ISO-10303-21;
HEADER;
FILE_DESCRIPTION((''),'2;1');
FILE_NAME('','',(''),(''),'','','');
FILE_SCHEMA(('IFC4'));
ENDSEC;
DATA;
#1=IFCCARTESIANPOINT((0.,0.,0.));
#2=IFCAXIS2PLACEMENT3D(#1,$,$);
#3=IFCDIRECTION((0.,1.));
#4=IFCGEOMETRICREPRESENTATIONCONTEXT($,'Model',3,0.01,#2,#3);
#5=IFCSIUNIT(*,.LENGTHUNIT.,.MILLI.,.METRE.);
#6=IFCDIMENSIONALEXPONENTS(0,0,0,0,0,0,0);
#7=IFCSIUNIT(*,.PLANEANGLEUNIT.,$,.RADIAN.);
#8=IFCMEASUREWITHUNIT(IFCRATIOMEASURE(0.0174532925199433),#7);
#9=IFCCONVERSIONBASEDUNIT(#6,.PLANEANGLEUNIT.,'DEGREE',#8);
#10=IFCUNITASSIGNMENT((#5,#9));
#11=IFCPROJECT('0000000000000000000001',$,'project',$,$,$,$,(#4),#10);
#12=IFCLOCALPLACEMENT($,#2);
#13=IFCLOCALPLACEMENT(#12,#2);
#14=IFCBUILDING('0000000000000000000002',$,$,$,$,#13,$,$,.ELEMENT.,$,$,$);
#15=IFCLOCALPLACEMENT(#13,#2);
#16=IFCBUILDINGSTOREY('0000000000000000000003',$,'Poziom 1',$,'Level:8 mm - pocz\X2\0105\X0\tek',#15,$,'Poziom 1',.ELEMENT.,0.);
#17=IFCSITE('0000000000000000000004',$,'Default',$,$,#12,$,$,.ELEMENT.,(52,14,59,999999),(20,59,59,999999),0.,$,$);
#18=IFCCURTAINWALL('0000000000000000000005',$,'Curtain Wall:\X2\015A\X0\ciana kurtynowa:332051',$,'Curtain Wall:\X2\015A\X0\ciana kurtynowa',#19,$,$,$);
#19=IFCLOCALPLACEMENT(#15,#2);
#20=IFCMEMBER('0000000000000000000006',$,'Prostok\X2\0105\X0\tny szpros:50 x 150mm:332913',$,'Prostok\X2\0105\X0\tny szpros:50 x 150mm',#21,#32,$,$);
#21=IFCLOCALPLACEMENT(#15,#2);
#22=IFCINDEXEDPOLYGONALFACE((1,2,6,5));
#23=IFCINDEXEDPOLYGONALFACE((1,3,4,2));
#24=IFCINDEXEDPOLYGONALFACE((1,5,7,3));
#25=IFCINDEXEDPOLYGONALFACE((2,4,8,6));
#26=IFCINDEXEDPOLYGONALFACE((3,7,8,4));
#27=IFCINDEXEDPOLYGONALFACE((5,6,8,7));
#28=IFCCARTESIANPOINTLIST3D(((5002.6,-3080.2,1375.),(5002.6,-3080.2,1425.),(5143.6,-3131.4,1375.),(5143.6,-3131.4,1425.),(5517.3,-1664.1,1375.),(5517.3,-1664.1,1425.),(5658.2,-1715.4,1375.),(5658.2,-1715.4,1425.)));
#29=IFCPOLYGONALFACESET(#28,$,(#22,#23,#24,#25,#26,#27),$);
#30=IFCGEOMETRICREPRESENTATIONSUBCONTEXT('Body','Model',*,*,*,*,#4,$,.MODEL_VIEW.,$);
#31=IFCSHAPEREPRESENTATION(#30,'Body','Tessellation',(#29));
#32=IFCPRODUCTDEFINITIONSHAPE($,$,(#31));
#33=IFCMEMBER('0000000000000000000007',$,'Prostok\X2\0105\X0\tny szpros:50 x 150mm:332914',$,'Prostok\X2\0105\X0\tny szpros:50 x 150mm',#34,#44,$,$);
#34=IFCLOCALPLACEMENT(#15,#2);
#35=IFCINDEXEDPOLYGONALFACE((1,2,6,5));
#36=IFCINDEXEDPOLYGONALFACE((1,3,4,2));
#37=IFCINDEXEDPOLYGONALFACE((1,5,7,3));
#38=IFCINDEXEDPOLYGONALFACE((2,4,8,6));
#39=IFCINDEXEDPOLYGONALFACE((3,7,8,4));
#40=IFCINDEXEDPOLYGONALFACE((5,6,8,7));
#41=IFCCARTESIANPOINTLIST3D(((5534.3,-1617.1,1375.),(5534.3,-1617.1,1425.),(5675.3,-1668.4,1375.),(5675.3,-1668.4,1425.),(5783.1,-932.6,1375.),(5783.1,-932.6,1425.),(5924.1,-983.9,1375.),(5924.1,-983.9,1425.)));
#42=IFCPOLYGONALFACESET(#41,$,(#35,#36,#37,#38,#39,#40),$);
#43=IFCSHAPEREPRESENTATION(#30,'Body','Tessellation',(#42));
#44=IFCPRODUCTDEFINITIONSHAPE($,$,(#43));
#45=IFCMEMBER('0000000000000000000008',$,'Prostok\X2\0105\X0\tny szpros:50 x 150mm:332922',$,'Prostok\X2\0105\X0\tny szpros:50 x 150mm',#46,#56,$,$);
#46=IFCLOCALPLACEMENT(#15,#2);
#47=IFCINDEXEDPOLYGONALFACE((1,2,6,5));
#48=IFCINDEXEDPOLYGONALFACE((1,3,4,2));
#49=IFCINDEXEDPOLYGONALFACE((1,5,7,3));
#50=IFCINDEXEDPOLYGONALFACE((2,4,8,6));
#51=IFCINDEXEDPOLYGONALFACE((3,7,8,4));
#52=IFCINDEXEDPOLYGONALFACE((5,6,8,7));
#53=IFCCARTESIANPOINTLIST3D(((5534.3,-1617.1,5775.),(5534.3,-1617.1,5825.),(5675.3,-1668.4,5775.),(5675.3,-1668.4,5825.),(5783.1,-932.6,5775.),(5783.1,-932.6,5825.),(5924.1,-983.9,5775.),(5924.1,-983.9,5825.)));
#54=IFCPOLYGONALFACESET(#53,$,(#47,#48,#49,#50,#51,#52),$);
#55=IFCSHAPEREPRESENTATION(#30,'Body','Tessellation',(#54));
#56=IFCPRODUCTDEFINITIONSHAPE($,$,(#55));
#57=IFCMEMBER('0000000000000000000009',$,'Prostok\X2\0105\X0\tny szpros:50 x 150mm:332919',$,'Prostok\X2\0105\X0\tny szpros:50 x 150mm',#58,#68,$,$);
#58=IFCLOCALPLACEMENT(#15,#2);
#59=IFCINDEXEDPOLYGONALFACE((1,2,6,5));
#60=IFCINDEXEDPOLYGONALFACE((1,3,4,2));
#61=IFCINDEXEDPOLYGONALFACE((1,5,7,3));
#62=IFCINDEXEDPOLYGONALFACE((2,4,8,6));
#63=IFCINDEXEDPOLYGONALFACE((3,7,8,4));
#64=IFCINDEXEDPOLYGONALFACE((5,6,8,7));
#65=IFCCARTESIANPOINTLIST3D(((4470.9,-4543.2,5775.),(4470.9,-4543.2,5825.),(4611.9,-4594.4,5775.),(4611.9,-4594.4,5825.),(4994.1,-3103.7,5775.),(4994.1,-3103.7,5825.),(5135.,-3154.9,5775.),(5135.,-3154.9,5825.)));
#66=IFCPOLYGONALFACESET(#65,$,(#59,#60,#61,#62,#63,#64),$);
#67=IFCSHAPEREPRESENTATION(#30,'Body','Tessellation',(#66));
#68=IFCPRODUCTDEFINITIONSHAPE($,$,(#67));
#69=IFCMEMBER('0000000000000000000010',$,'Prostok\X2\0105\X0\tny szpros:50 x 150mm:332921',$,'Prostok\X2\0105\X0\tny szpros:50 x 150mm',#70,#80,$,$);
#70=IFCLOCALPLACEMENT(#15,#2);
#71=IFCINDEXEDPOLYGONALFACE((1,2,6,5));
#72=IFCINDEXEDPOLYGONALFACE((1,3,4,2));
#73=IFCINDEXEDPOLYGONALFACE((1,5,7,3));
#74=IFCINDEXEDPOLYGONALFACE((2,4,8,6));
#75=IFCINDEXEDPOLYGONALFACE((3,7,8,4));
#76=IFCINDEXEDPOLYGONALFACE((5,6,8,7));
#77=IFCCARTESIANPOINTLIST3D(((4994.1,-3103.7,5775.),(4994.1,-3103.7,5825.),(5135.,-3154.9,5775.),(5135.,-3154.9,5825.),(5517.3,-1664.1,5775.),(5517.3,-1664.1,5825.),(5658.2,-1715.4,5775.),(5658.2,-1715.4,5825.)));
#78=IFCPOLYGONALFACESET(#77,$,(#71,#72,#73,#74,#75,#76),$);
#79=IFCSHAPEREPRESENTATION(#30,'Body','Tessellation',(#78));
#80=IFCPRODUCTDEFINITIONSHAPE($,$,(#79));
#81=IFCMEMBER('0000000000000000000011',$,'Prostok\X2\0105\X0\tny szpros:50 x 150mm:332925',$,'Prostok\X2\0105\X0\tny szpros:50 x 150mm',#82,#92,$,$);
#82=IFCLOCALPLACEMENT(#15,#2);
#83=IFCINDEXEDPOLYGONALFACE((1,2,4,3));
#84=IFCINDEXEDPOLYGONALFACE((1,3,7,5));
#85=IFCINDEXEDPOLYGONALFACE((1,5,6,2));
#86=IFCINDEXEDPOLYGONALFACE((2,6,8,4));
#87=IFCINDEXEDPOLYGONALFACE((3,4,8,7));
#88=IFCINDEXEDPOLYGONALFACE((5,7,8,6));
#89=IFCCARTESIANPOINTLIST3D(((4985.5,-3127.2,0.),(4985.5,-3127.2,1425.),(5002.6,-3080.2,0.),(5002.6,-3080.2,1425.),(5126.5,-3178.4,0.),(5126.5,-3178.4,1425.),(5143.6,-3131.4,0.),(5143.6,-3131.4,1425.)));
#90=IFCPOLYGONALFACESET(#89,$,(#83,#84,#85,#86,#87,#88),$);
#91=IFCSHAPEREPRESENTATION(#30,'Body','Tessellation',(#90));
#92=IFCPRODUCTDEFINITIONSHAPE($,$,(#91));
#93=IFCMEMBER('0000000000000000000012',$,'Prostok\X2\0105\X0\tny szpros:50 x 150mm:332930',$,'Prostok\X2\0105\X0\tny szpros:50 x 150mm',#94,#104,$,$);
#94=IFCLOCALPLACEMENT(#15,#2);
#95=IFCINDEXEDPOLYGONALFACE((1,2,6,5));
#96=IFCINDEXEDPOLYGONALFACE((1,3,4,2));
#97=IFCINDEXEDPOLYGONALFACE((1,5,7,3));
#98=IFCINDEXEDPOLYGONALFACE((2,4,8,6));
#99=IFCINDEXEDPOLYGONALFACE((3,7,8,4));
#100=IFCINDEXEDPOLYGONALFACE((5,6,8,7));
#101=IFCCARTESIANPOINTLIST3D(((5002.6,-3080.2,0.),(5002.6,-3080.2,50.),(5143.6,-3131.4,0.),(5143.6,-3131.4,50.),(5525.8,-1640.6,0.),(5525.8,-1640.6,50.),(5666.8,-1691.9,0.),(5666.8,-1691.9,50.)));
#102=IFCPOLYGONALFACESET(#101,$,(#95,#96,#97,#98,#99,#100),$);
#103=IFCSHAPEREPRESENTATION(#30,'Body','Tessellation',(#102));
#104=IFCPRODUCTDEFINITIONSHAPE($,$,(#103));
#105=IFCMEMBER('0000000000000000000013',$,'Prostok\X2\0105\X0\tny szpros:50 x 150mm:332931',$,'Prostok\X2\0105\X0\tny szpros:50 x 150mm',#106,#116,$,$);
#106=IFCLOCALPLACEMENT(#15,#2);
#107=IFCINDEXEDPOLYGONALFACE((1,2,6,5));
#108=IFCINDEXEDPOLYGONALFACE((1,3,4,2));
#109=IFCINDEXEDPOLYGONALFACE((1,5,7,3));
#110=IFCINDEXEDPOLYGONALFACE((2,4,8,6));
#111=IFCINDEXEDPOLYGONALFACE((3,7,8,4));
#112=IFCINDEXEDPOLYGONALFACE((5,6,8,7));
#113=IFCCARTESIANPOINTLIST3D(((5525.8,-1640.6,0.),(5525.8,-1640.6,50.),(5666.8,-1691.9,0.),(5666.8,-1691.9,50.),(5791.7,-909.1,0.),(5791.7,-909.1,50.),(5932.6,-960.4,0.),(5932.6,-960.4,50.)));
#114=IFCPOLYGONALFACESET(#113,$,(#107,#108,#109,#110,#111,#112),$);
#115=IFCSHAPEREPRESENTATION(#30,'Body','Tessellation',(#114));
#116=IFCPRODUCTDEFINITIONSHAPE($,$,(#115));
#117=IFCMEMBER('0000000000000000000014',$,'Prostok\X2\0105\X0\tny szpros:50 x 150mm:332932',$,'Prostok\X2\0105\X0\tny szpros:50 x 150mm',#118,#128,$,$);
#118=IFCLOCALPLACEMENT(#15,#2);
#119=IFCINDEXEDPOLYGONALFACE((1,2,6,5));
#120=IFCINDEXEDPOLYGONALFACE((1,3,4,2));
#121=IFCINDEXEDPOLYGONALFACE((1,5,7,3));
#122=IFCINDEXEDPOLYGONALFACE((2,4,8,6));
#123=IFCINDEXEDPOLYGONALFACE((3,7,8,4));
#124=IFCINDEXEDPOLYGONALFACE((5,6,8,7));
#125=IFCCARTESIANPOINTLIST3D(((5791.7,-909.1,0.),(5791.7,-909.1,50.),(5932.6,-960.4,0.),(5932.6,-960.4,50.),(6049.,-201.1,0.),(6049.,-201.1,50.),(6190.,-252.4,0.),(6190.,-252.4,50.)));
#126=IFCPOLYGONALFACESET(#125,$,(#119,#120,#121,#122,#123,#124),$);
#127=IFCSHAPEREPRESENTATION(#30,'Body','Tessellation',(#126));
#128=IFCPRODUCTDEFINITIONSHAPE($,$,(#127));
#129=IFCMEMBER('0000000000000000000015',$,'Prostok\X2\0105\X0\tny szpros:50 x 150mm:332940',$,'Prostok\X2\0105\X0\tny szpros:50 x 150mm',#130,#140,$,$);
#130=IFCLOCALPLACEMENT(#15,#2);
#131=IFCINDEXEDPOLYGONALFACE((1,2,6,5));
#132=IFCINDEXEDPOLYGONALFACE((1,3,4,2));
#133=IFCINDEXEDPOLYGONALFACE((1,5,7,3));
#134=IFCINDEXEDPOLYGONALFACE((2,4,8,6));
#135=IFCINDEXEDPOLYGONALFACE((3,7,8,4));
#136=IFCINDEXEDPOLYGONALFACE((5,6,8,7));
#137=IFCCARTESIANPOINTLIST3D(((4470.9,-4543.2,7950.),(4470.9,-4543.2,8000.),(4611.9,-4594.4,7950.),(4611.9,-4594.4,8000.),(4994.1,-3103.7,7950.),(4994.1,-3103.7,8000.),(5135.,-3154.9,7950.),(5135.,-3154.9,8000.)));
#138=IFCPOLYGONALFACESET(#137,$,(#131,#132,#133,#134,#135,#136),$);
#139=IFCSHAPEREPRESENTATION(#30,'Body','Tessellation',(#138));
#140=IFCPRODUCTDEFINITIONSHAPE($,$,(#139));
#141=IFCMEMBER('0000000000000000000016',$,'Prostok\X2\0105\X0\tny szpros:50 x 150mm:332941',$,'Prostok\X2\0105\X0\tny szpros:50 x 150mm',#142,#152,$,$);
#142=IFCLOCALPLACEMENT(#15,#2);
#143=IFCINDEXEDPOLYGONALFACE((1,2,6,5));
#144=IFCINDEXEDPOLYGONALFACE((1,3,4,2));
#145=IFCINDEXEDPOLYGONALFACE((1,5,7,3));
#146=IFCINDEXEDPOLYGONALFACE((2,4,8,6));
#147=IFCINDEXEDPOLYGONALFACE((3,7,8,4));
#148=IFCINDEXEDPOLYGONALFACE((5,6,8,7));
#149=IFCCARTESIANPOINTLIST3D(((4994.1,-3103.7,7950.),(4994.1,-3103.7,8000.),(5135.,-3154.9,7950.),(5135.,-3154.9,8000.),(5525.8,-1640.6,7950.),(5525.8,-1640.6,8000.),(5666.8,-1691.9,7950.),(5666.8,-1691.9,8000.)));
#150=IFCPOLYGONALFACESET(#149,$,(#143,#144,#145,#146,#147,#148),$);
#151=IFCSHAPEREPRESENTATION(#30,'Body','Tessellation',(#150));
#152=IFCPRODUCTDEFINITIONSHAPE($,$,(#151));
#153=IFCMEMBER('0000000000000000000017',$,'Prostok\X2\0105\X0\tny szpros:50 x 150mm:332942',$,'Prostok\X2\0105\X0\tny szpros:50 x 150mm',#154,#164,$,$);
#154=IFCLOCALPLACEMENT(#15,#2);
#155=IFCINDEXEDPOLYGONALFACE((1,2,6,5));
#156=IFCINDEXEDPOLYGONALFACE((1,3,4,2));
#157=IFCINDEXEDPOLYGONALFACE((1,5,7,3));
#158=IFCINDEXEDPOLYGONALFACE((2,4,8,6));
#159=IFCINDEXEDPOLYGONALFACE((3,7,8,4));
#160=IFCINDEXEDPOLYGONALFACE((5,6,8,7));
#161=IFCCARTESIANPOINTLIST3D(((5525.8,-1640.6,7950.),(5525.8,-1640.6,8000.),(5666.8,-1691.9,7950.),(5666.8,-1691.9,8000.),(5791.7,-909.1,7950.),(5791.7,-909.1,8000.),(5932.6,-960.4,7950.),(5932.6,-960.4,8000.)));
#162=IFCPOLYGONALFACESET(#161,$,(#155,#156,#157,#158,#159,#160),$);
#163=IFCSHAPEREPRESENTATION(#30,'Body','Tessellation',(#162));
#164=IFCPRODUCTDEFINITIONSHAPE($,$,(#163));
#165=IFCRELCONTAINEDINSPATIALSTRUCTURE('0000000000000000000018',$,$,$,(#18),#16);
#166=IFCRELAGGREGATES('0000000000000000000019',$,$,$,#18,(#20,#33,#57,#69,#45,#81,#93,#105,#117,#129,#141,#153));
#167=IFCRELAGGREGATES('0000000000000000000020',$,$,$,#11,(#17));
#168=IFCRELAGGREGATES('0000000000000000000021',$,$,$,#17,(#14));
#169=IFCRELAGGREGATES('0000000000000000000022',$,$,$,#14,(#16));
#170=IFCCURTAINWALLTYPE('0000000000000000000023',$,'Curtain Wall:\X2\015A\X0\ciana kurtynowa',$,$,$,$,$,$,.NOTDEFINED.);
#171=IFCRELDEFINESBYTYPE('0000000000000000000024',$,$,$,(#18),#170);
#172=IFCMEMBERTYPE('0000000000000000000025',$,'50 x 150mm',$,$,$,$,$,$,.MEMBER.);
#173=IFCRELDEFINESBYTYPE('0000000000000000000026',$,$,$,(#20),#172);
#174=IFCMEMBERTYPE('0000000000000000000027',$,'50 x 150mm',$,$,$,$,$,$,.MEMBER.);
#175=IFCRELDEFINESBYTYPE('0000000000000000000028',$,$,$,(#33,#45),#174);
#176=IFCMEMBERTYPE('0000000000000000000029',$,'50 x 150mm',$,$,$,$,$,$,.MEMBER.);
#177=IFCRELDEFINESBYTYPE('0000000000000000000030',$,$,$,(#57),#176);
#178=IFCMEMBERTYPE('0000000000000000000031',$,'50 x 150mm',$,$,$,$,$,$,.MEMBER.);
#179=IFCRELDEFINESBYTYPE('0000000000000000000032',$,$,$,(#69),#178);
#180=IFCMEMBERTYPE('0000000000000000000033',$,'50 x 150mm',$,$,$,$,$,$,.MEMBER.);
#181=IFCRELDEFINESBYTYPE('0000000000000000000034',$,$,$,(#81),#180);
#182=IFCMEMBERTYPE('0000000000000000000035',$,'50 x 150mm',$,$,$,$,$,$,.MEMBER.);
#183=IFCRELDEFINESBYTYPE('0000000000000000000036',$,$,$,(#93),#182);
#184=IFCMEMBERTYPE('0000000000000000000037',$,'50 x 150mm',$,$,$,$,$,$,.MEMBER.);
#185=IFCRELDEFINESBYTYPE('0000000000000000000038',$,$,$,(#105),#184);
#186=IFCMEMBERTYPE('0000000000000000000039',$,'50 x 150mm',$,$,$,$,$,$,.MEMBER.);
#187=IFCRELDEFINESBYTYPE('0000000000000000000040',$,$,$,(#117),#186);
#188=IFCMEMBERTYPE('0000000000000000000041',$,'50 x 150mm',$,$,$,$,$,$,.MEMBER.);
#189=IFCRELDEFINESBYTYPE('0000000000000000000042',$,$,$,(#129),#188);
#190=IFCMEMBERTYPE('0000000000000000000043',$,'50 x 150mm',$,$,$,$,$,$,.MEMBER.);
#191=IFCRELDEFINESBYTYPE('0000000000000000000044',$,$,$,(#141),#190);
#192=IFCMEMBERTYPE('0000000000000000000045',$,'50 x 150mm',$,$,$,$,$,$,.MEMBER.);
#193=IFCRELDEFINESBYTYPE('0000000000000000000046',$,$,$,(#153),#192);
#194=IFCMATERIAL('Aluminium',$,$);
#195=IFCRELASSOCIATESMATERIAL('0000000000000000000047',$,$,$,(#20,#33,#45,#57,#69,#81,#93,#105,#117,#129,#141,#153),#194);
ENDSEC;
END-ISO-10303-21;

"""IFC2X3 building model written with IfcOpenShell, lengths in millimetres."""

from ifc_helpers import new_model, entity, si_unit, converted_unit, direction, frame, origin, origin_2d_with_axis, place, context, subcontext, project, spatial, rectangle, extrude, source, transform, mapped, material, type_object, type_shapes, element, aggregate, save


model = new_model("IFC2X3")

# Units and contexts
model_context = context("Model", 3, precision=0.01, world=origin(), true_north=direction((0.0, 1.0)))
body_context = subcontext(model_context, "Body", "Model", "MODEL_VIEW")
ifc_project = project(units=[si_unit("LENGTHUNIT", "METRE", prefix="MILLI"), converted_unit("PLANEANGLEUNIT", "DEGREE", entity("IfcRatioMeasure", 0.0174532925199433), si_unit("PLANEANGLEUNIT", "RADIAN"), dimensions=[0, 0, 0, 0, 0, 0, 0])], contexts=[model_context])

# Site, building, storey
site_placement = place(None, origin())
site = spatial("IfcSite", under=ifc_project, at=site_placement, Name="Default", CompositionType="ELEMENT", RefLatitude=(52, 14, 59, 999999), RefLongitude=(20, 59, 59, 999999), RefElevation=0.0)
building_placement = place(site_placement, origin())
building = spatial("IfcBuilding", under=site, at=building_placement, CompositionType="ELEMENT")
storey_placement = place(building_placement, origin())
storey = spatial("IfcBuildingStorey", under=building, at=storey_placement, Name="Poziom 1", ObjectType="Level:8 mm - początek", LongName="Poziom 1", CompositionType="ELEMENT", Elevation=0.0)

# Curtain wall, members
curtain_wall_type = type_object("IfcCurtainWallType", Name="Curtain Wall:Ściana kurtynowa", PredefinedType="NOTDEFINED")
curtain_wall_placement = place(storey_placement, origin())
curtain_wall = element("IfcCurtainWall", 1, at=curtain_wall_placement, inside=storey, type_object=curtain_wall_type, Name="Curtain Wall:Ściana kurtynowa:332051", ObjectType="Curtain Wall:Ściana kurtynowa")
ifc_material_1 = material(Name="Aluminium")
member_type_1 = type_object("IfcMemberType", Name="50 x 150mm", PredefinedType="MEMBER")
shared_shape_1 = source(origin(), body_context, "Body", "SweptSolid", [
    extrude(rectangle(XDim=150.0, YDim=50.0, at=origin_2d_with_axis()), frame((0.0, 0.0, -1506.6), z_axis=(0.0, 0.0, 1.0), x_axis=(0.0, -1.0, 0.0)), (0.0, 0.0, 1.0), 1506.6),
])
type_shapes(member_type_1, [shared_shape_1])
member_1_placement = place(storey_placement, frame((5587.7, -1689.8, 1400.0), z_axis=(0.341586, 0.939851, 0.0), x_axis=(0.0, 0.0, 1.0)))
member_1 = element("IfcMember", 2, at=member_1_placement, type_object=member_type_1, material=ifc_material_1, Name="Prostokątny szpros:50 x 150mm:332913", ObjectType="Prostokątny szpros:50 x 150mm", context=body_context, shape_type="MappedRepresentation", body=[
    mapped(shared_shape_1, transform((0.0, 0.0, 0.0), scale=1.0)),
])
member_type_2 = type_object("IfcMemberType", Name="50 x 150mm", PredefinedType="MEMBER")
shared_shape_2 = source(origin(), body_context, "Body", "SweptSolid", [
    extrude(rectangle(XDim=150.0, YDim=50.0, at=origin_2d_with_axis()), frame((0.0, 0.0, -728.3), z_axis=(0.0, 0.0, 1.0), x_axis=(0.0, -1.0, 0.0)), (0.0, 0.0, 1.0), 728.3),
])
type_shapes(member_type_2, [shared_shape_2])
member_2_placement = place(storey_placement, frame((5853.6, -958.2, 1400.0), z_axis=(0.341586, 0.939851, 0.0), x_axis=(0.0, 0.0, 1.0)))
member_2 = element("IfcMember", 3, at=member_2_placement, type_object=member_type_2, material=ifc_material_1, Name="Prostokątny szpros:50 x 150mm:332914", ObjectType="Prostokątny szpros:50 x 150mm", context=body_context, shape_type="MappedRepresentation", body=[
    mapped(shared_shape_2, transform((0.0, 0.0, 0.0), scale=1.0)),
])
member_3_placement = place(storey_placement, frame((5853.6, -958.2, 5800.0), z_axis=(0.341586, 0.939851, 0.0), x_axis=(0.0, 0.0, 1.0)))
member_3 = element("IfcMember", 4, at=member_3_placement, type_object=member_type_2, material=ifc_material_1, Name="Prostokątny szpros:50 x 150mm:332922", ObjectType="Prostokątny szpros:50 x 150mm", context=body_context, shape_type="MappedRepresentation", body=[
    mapped(shared_shape_2, transform((0.0, 0.0, 0.0), scale=1.0)),
])
member_type_3 = type_object("IfcMemberType", Name="50 x 150mm", PredefinedType="MEMBER")
shared_shape_3 = source(origin(), body_context, "Body", "SweptSolid", [
    extrude(rectangle(XDim=150.0, YDim=50.0, at=origin_2d_with_axis()), frame((0.0, 0.0, -1531.6), z_axis=(0.0, 0.0, 1.0), x_axis=(0.0, -1.0, 0.0)), (0.0, 0.0, 1.0), 1531.6),
])
type_shapes(member_type_3, [shared_shape_3])
member_4_placement = place(storey_placement, frame((5064.6, -3129.3, 5800.0), z_axis=(0.341586, 0.939851, 0.0), x_axis=(0.0, 0.0, 1.0)))
member_4 = element("IfcMember", 5, at=member_4_placement, type_object=member_type_3, material=ifc_material_1, Name="Prostokątny szpros:50 x 150mm:332919", ObjectType="Prostokątny szpros:50 x 150mm", context=body_context, shape_type="MappedRepresentation", body=[
    mapped(shared_shape_3, transform((0.0, 0.0, 0.0), scale=1.0)),
])
member_type_4 = type_object("IfcMemberType", Name="50 x 150mm", PredefinedType="MEMBER")
shared_shape_4 = source(origin(), body_context, "Body", "SweptSolid", [
    extrude(rectangle(XDim=150.0, YDim=50.0, at=origin_2d_with_axis()), frame((0.0, 0.0, -1531.6), z_axis=(0.0, 0.0, 1.0), x_axis=(0.0, -1.0, 0.0)), (0.0, 0.0, 1.0), 1531.6),
])
type_shapes(member_type_4, [shared_shape_4])
member_5_placement = place(storey_placement, frame((5587.7, -1689.8, 5800.0), z_axis=(0.341586, 0.939851, 0.0), x_axis=(0.0, 0.0, 1.0)))
member_5 = element("IfcMember", 6, at=member_5_placement, type_object=member_type_4, material=ifc_material_1, Name="Prostokątny szpros:50 x 150mm:332921", ObjectType="Prostokątny szpros:50 x 150mm", context=body_context, shape_type="MappedRepresentation", body=[
    mapped(shared_shape_4, transform((0.0, 0.0, 0.0), scale=1.0)),
])
member_type_5 = type_object("IfcMemberType", Name="50 x 150mm", PredefinedType="MEMBER")
shared_shape_5 = source(origin(), body_context, "Body", "SweptSolid", [
    extrude(rectangle(XDim=150.0, YDim=50.0, at=origin_2d_with_axis()), frame((0.0, 0.0, -1425.0), z_axis=(0.0, 0.0, 1.0), x_axis=(0.0, -1.0, 0.0)), (0.0, 0.0, 1.0), 1425.0),
])
type_shapes(member_type_5, [shared_shape_5])
member_6_placement = place(storey_placement, frame((5064.6, -3129.3, 0.0), z_axis=(0.0, 0.0, -1.0), x_axis=(0.341586, 0.939851, 0.0)))
member_6 = element("IfcMember", 7, at=member_6_placement, type_object=member_type_5, material=ifc_material_1, Name="Prostokątny szpros:50 x 150mm:332925", ObjectType="Prostokątny szpros:50 x 150mm", context=body_context, shape_type="MappedRepresentation", body=[
    mapped(shared_shape_5, transform((0.0, 0.0, 0.0), scale=1.0)),
])
member_type_6 = type_object("IfcMemberType", Name="50 x 150mm", PredefinedType="MEMBER")
shared_shape_6 = source(origin(), body_context, "Body", "SweptSolid", [
    extrude(rectangle(XDim=150.0, YDim=50.0, at=origin_2d_with_axis()), frame((-25.0, 0.0, -1531.6), z_axis=(0.0, 0.0, 1.0), x_axis=(0.0, -1.0, 0.0)), (0.0, 0.0, 1.0), 1531.6),
])
type_shapes(member_type_6, [shared_shape_6])
member_7_placement = place(storey_placement, frame((5073.1, -3105.8, 0.0), z_axis=(-0.341586, -0.939851, 0.0), x_axis=(0.0, 0.0, -1.0)))
member_7 = element("IfcMember", 8, at=member_7_placement, type_object=member_type_6, material=ifc_material_1, Name="Prostokątny szpros:50 x 150mm:332930", ObjectType="Prostokątny szpros:50 x 150mm", context=body_context, shape_type="MappedRepresentation", body=[
    mapped(shared_shape_6, transform((0.0, 0.0, 0.0), scale=1.0)),
])
member_type_7 = type_object("IfcMemberType", Name="50 x 150mm", PredefinedType="MEMBER")
shared_shape_7 = source(origin(), body_context, "Body", "SweptSolid", [
    extrude(rectangle(XDim=150.0, YDim=50.0, at=origin_2d_with_axis()), frame((-25.0, 0.0, -778.3), z_axis=(0.0, 0.0, 1.0), x_axis=(0.0, -1.0, 0.0)), (0.0, 0.0, 1.0), 778.3),
])
type_shapes(member_type_7, [shared_shape_7])
member_8_placement = place(storey_placement, frame((5596.3, -1666.3, 0.0), z_axis=(-0.341586, -0.939851, 0.0), x_axis=(0.0, 0.0, -1.0)))
member_8 = element("IfcMember", 9, at=member_8_placement, type_object=member_type_7, material=ifc_material_1, Name="Prostokątny szpros:50 x 150mm:332931", ObjectType="Prostokątny szpros:50 x 150mm", context=body_context, shape_type="MappedRepresentation", body=[
    mapped(shared_shape_7, transform((0.0, 0.0, 0.0), scale=1.0)),
])
member_type_8 = type_object("IfcMemberType", Name="50 x 150mm", PredefinedType="MEMBER")
shared_shape_8 = source(origin(), body_context, "Body", "SweptSolid", [
    extrude(rectangle(XDim=150.0, YDim=50.0, at=origin_2d_with_axis()), frame((-25.0, 0.0, -753.3), z_axis=(0.0, 0.0, 1.0), x_axis=(0.0, -1.0, 0.0)), (0.0, 0.0, 1.0), 753.3),
])
type_shapes(member_type_8, [shared_shape_8])
member_9_placement = place(storey_placement, frame((5862.1, -934.8, 0.0), z_axis=(-0.341586, -0.939851, 0.0), x_axis=(0.0, 0.0, -1.0)))
member_9 = element("IfcMember", 10, at=member_9_placement, type_object=member_type_8, material=ifc_material_1, Name="Prostokątny szpros:50 x 150mm:332932", ObjectType="Prostokątny szpros:50 x 150mm", context=body_context, shape_type="MappedRepresentation", body=[
    mapped(shared_shape_8, transform((0.0, 0.0, 0.0), scale=1.0)),
])
member_type_9 = type_object("IfcMemberType", Name="50 x 150mm", PredefinedType="MEMBER")
shared_shape_9 = source(origin(), body_context, "Body", "SweptSolid", [
    extrude(rectangle(XDim=150.0, YDim=50.0, at=origin_2d_with_axis()), frame((-25.0, 0.0, -1531.6), z_axis=(0.0, 0.0, 1.0), x_axis=(0.0, -1.0, 0.0)), (0.0, 0.0, 1.0), 1531.6),
])
type_shapes(member_type_9, [shared_shape_9])
member_10_placement = place(storey_placement, frame((5064.6, -3129.3, 8000.0), z_axis=(0.341586, 0.939851, 0.0), x_axis=(0.0, 0.0, 1.0)))
member_10 = element("IfcMember", 11, at=member_10_placement, type_object=member_type_9, material=ifc_material_1, Name="Prostokątny szpros:50 x 150mm:332940", ObjectType="Prostokątny szpros:50 x 150mm", context=body_context, shape_type="MappedRepresentation", body=[
    mapped(shared_shape_9, transform((0.0, 0.0, 0.0), scale=1.0)),
])
member_type_10 = type_object("IfcMemberType", Name="50 x 150mm", PredefinedType="MEMBER")
shared_shape_10 = source(origin(), body_context, "Body", "SweptSolid", [
    extrude(rectangle(XDim=150.0, YDim=50.0, at=origin_2d_with_axis()), frame((-25.0, 0.0, -1556.6), z_axis=(0.0, 0.0, 1.0), x_axis=(0.0, -1.0, 0.0)), (0.0, 0.0, 1.0), 1556.6),
])
type_shapes(member_type_10, [shared_shape_10])
member_11_placement = place(storey_placement, frame((5596.3, -1666.3, 8000.0), z_axis=(0.341586, 0.939851, 0.0), x_axis=(0.0, 0.0, 1.0)))
member_11 = element("IfcMember", 12, at=member_11_placement, type_object=member_type_10, material=ifc_material_1, Name="Prostokątny szpros:50 x 150mm:332941", ObjectType="Prostokątny szpros:50 x 150mm", context=body_context, shape_type="MappedRepresentation", body=[
    mapped(shared_shape_10, transform((0.0, 0.0, 0.0), scale=1.0)),
])
member_type_11 = type_object("IfcMemberType", Name="50 x 150mm", PredefinedType="MEMBER")
shared_shape_11 = source(origin(), body_context, "Body", "SweptSolid", [
    extrude(rectangle(XDim=150.0, YDim=50.0, at=origin_2d_with_axis()), frame((-25.0, 0.0, -778.3), z_axis=(0.0, 0.0, 1.0), x_axis=(0.0, -1.0, 0.0)), (0.0, 0.0, 1.0), 778.3),
])
type_shapes(member_type_11, [shared_shape_11])
member_12_placement = place(storey_placement, frame((5862.1, -934.8, 8000.0), z_axis=(0.341586, 0.939851, 0.0), x_axis=(0.0, 0.0, 1.0)))
member_12 = element("IfcMember", 13, at=member_12_placement, type_object=member_type_11, material=ifc_material_1, Name="Prostokątny szpros:50 x 150mm:332942", ObjectType="Prostokątny szpros:50 x 150mm", context=body_context, shape_type="MappedRepresentation", body=[
    mapped(shared_shape_11, transform((0.0, 0.0, 0.0), scale=1.0)),
])

aggregate(curtain_wall, [member_1, member_2, member_4, member_5, member_3, member_6, member_7, member_8, member_9, member_10, member_11, member_12])

save(model, "model.ifc")
